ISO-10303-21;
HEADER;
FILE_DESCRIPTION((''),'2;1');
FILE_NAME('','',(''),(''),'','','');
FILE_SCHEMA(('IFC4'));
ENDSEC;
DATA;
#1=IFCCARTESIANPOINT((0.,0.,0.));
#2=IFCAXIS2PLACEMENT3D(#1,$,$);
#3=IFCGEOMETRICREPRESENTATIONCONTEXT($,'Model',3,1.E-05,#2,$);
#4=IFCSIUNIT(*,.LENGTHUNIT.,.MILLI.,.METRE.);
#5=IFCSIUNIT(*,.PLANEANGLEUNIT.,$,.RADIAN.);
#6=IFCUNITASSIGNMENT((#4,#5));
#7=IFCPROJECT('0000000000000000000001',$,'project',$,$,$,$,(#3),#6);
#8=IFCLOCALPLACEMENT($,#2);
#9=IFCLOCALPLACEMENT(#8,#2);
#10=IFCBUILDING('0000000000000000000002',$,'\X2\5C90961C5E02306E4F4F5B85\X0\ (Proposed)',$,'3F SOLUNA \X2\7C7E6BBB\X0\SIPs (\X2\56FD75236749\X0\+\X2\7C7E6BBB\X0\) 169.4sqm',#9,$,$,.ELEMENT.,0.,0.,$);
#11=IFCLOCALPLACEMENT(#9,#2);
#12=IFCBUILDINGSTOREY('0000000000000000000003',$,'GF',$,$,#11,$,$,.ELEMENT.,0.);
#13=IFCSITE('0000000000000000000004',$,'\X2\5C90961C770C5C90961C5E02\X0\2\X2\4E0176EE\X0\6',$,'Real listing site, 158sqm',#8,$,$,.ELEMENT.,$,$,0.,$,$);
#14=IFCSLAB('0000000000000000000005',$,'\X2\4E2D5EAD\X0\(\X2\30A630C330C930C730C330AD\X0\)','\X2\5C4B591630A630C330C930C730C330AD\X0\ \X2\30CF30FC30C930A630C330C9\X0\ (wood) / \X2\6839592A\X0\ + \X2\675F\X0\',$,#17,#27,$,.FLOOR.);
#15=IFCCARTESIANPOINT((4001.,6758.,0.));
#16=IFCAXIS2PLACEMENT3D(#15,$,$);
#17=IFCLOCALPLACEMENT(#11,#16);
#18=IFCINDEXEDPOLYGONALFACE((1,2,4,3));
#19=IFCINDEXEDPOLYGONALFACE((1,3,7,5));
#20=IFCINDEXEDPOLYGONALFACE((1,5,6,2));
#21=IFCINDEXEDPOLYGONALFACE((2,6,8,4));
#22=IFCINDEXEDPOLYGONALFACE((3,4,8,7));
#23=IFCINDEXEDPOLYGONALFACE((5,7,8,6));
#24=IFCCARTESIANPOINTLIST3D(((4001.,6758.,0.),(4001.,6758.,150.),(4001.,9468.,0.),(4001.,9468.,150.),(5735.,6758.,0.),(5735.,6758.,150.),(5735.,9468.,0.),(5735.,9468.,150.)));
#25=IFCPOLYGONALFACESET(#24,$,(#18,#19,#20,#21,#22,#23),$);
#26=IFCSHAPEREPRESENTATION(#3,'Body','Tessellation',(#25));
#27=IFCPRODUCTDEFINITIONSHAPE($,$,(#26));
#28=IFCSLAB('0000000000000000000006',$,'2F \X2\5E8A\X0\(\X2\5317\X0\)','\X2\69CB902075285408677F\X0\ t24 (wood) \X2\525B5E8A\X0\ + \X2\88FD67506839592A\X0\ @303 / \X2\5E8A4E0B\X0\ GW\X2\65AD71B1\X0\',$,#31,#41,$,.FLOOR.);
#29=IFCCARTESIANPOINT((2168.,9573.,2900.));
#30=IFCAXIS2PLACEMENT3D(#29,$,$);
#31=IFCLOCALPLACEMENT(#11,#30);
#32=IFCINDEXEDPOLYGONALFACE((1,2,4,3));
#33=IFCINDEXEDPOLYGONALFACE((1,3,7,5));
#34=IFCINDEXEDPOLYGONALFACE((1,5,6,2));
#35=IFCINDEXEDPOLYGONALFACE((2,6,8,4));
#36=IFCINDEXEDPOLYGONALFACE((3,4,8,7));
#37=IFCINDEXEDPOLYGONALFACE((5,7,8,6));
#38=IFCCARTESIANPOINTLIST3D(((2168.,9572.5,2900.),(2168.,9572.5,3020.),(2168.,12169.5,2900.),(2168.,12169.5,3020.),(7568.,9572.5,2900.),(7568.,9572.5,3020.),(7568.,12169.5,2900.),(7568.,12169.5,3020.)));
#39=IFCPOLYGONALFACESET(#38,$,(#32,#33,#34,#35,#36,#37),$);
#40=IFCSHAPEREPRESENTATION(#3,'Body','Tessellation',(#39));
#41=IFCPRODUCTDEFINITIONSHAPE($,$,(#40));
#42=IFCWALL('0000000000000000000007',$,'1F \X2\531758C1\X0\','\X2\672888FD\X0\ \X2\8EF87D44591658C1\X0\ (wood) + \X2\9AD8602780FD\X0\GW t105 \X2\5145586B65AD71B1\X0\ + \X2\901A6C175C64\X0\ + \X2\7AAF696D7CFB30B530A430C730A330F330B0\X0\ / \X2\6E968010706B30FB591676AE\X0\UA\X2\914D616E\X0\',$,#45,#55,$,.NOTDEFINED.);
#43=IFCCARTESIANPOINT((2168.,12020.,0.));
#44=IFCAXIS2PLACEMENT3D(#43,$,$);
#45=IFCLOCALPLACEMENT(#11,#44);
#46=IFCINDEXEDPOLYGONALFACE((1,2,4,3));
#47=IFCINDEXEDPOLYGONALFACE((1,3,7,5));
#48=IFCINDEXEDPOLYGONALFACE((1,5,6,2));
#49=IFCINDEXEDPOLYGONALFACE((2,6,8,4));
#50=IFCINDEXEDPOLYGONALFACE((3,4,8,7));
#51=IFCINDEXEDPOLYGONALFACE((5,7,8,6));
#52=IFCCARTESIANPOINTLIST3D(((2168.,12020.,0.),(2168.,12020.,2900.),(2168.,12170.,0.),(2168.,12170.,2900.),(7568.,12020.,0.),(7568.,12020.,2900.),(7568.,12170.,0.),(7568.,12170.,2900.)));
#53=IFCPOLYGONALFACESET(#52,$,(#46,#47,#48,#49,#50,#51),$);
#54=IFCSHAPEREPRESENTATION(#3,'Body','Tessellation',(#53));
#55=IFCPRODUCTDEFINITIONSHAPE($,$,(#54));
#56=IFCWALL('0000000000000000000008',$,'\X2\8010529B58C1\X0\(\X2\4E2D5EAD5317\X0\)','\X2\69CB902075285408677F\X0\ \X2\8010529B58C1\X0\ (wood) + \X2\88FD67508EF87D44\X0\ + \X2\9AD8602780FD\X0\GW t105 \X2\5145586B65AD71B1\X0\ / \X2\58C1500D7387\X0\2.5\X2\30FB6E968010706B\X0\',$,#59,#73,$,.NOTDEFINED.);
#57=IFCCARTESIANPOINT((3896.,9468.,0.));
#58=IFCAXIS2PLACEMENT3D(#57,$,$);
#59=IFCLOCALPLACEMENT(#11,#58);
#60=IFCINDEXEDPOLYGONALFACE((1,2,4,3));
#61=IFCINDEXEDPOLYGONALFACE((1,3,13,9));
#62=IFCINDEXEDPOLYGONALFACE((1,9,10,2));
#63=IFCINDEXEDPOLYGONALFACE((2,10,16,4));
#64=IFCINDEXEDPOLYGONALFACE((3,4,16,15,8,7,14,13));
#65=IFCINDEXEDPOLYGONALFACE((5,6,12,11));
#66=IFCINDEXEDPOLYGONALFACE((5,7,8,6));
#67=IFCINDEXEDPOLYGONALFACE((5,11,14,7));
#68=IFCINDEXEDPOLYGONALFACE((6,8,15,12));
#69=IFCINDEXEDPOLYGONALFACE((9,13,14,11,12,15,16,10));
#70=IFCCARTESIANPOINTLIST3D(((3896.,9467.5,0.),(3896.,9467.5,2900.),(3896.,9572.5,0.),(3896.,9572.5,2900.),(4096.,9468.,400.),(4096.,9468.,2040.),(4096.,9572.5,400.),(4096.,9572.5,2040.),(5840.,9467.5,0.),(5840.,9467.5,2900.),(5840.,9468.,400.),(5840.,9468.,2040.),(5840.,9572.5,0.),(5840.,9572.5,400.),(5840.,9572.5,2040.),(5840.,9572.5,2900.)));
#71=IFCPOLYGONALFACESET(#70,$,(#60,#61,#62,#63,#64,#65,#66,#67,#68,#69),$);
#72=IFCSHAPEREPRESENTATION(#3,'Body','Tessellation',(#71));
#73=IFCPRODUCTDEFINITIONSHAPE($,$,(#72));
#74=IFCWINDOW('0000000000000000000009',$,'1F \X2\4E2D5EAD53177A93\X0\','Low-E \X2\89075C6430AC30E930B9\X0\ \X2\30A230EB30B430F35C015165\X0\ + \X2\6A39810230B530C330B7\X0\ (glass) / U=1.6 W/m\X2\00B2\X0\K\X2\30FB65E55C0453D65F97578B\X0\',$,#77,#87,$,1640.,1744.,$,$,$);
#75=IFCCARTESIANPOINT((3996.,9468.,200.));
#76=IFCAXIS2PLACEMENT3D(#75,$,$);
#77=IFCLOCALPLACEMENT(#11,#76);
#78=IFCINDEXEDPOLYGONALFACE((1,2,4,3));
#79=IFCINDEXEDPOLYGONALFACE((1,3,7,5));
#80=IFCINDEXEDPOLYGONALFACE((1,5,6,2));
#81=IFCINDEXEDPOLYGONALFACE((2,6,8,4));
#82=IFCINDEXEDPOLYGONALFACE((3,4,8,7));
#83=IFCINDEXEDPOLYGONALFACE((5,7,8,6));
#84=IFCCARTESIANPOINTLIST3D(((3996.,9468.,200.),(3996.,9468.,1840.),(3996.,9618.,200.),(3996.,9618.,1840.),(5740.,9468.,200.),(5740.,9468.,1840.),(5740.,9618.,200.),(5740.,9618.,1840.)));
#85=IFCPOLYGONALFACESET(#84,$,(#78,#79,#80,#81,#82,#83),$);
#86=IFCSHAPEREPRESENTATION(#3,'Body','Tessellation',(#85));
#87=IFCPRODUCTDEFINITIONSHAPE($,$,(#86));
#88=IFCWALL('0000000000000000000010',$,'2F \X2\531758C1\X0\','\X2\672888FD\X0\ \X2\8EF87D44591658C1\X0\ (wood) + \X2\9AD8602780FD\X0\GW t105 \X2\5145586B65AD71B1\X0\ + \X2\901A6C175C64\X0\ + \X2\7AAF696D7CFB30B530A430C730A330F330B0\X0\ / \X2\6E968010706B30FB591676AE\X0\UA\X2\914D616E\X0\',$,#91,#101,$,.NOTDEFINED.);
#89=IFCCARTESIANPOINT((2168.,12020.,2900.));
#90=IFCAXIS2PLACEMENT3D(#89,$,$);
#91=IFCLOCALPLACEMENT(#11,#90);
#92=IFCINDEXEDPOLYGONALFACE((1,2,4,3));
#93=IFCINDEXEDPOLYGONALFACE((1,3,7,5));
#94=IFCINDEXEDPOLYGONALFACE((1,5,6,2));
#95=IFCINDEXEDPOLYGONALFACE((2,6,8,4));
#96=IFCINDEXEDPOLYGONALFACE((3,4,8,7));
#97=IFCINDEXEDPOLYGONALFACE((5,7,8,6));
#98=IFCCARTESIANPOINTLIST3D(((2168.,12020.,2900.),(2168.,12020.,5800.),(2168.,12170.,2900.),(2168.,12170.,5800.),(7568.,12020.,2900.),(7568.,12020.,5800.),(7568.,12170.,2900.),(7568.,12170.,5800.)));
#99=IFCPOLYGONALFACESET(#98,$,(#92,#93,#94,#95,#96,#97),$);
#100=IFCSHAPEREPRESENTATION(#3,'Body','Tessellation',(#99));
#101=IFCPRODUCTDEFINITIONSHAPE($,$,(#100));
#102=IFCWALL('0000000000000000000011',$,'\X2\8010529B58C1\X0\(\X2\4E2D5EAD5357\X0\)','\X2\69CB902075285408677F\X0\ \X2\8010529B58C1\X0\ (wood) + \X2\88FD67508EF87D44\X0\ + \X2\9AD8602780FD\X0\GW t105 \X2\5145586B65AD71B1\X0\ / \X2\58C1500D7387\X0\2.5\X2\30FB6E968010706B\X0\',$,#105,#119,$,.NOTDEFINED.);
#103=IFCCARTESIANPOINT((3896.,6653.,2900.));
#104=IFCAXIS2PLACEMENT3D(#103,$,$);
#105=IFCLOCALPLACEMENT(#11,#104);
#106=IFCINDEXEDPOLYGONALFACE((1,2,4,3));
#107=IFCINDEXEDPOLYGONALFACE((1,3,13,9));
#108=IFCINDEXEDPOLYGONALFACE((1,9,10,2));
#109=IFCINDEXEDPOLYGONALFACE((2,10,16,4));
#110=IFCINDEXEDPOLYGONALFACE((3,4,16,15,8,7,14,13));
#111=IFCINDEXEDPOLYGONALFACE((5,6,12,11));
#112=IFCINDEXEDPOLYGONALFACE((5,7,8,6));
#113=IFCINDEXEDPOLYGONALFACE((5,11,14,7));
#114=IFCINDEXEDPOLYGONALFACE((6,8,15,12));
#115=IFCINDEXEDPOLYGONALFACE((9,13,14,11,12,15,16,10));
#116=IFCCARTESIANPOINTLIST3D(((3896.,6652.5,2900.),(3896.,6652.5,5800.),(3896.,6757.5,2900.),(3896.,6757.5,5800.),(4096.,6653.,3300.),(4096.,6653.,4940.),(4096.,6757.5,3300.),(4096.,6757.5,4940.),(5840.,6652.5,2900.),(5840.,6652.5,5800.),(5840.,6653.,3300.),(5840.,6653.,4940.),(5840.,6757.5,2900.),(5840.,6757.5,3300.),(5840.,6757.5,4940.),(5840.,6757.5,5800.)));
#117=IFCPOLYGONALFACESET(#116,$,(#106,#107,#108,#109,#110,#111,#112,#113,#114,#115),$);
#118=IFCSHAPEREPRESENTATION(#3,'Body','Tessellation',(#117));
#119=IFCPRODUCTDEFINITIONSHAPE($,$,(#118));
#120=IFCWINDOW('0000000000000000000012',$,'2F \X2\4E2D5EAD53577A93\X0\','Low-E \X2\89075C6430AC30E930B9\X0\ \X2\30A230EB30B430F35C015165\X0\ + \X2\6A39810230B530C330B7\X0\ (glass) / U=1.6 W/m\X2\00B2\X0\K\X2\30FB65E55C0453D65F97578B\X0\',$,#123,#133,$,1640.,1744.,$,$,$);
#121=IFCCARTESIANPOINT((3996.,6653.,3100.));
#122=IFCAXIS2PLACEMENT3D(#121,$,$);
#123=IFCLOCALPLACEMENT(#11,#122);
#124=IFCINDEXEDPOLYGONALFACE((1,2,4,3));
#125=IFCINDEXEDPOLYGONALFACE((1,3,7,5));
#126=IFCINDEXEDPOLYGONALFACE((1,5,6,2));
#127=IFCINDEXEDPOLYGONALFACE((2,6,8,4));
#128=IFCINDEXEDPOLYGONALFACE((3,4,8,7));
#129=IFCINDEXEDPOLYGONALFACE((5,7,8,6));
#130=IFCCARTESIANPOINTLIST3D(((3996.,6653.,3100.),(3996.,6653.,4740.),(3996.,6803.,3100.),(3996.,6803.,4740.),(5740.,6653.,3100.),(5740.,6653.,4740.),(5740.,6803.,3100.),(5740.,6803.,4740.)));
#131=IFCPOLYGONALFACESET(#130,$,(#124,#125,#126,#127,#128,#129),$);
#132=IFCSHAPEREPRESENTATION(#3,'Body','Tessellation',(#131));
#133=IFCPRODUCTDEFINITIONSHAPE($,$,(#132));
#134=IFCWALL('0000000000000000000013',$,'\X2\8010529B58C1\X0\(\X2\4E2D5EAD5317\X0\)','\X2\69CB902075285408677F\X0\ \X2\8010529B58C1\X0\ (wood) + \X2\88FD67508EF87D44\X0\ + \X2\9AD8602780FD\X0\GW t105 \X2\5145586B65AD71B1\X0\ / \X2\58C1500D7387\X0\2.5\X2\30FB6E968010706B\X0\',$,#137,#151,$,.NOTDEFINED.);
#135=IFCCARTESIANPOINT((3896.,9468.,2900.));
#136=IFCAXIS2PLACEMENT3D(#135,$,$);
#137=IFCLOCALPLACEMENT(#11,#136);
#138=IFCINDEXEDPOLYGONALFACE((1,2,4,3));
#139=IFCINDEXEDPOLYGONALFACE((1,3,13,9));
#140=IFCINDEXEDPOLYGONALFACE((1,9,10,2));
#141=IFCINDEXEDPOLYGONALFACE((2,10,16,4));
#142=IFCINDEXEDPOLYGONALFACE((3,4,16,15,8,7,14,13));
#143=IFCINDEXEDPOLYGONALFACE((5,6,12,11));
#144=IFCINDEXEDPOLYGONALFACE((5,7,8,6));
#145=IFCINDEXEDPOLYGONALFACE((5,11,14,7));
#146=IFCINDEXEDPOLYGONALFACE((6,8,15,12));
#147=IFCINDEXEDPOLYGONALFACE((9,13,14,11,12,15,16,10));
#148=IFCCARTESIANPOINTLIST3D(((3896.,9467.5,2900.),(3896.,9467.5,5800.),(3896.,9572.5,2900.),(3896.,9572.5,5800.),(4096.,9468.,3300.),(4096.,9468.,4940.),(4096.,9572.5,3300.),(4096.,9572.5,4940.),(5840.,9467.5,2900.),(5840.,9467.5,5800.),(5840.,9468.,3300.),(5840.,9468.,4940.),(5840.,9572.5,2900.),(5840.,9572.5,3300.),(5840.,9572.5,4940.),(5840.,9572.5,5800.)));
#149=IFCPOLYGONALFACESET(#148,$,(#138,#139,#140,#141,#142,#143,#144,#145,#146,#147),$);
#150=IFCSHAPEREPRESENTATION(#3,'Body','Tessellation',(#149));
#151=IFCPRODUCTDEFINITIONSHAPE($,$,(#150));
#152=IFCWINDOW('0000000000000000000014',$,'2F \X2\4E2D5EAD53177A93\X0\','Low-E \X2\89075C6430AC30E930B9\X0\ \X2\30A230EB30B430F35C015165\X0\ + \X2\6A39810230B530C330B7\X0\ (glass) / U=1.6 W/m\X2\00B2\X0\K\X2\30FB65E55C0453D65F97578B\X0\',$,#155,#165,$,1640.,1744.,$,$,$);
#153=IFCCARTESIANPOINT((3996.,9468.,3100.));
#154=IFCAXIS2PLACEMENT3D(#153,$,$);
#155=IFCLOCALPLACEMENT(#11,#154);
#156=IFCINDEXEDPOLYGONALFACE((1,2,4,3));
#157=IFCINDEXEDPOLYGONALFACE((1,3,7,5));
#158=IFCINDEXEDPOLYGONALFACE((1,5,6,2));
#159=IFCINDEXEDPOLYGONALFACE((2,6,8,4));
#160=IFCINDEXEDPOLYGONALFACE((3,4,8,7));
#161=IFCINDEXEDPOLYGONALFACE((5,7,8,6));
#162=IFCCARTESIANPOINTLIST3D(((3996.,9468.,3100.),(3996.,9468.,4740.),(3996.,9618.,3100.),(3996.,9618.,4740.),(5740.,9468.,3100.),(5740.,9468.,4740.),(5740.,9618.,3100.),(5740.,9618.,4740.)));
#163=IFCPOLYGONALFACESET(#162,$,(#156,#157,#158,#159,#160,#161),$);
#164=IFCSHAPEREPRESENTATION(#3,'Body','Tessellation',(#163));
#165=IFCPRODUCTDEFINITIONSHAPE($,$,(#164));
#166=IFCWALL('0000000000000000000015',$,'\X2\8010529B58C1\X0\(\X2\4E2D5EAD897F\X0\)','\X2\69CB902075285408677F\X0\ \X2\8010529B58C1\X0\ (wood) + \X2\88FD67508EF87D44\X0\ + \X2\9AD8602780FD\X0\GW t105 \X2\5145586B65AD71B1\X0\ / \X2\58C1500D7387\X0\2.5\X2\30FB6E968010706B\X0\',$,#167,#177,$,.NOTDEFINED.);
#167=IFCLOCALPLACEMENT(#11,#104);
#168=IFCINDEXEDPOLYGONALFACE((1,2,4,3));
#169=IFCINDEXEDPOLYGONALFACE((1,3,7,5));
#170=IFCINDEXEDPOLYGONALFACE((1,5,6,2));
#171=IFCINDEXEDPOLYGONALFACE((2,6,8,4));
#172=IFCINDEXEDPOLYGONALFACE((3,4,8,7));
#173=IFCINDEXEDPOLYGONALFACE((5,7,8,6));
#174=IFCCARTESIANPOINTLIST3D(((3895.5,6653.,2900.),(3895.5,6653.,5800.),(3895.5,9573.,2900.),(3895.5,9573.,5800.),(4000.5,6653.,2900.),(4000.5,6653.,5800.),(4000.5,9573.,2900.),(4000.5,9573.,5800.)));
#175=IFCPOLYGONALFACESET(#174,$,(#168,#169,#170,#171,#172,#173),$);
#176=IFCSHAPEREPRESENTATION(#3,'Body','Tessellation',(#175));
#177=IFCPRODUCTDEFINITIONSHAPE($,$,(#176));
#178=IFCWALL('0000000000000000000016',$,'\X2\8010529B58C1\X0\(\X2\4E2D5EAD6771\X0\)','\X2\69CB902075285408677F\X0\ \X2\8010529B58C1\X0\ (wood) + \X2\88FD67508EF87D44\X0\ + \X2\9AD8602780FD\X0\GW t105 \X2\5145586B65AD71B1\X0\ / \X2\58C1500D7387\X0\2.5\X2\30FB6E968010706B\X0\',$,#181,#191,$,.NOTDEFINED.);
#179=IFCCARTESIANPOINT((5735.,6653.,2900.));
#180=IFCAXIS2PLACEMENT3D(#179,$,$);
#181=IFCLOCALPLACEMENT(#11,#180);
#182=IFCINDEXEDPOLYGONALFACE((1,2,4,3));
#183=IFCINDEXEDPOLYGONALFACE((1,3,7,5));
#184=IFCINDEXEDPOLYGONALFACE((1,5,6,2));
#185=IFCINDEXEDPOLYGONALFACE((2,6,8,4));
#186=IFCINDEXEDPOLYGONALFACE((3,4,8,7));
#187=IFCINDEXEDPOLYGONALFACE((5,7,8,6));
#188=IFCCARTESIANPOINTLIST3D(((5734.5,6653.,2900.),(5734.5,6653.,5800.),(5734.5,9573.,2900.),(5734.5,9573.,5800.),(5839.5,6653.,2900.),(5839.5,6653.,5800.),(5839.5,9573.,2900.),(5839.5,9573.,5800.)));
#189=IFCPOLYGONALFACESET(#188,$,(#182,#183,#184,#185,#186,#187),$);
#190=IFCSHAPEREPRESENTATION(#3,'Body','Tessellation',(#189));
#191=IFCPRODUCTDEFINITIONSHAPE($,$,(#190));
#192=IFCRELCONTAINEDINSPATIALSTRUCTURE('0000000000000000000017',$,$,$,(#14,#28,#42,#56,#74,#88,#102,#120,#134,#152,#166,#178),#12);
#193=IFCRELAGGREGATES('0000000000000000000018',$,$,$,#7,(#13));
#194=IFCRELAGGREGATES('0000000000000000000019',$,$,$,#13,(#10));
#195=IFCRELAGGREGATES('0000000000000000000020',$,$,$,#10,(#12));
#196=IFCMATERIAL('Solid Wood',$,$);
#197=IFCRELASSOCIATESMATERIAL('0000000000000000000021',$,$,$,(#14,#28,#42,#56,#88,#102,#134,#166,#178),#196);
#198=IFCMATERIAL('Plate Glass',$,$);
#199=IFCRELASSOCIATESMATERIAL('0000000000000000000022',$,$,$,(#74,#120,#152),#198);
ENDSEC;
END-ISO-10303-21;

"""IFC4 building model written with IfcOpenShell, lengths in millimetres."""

from ifc_helpers import new_model, si_unit, frame, frame_2d, origin, place, context, project, spatial, rectangle, extrude, material, element, fill, save


model = new_model("IFC4")

# Units and contexts
model_context = context("Model", 3, precision=1e-05, world=origin())
ifc_project = project(units=[si_unit("LENGTHUNIT", "METRE", prefix="MILLI"), si_unit("PLANEANGLEUNIT", "RADIAN")], contexts=[model_context])

# Site, building, storey
site_placement = place(None, origin())
site = spatial("IfcSite", under=ifc_project, at=site_placement, Name="岐阜県岐阜市2丁目6", ObjectType="Real listing site, 158sqm", CompositionType="ELEMENT", RefElevation=0.0)
building_placement = place(site_placement, origin())
building = spatial("IfcBuilding", under=site, at=building_placement, Name="岐阜市の住宅 (Proposed)", ObjectType="3F SOLUNA 籾殻SIPs (国産杉+籾殻) 169.4sqm", CompositionType="ELEMENT", ElevationOfRefHeight=0.0, ElevationOfTerrain=0.0)
storey_placement = place(building_placement, origin())
storey = spatial("IfcBuildingStorey", under=building, at=storey_placement, Name="GF", CompositionType="ELEMENT", Elevation=0.0)

# Slabs
ifc_material_1 = material(Name="Solid Wood")
slab_1_placement = place(storey_placement, frame((4001.0, 6758.0, 0.0)))
element("IfcSlab", 1, at=slab_1_placement, inside=storey, material=ifc_material_1, Name="中庭(ウッドデッキ)", Description="屋外ウッドデッキ ハードウッド (wood) / 根太 + 束", PredefinedType="FLOOR", context=model_context, shape_type="SweptSolid", body=[
    extrude(rectangle(XDim=1734.0, YDim=2710.0, at=frame_2d((867.0, 1355.0))), frame((4001.0, 6758.0, 0.0)), (0.0, 0.0, 1.0), 150.0),
])
slab_2_placement = place(storey_placement, frame((2168.0, 9573.0, 2900.0)))
element("IfcSlab", 2, at=slab_2_placement, inside=storey, material=ifc_material_1, Name="2F 床(北)", Description="構造用合板 t24 (wood) 剛床 + 製材根太 @303 / 床下 GW断熱", PredefinedType="FLOOR", context=model_context, shape_type="SweptSolid", body=[
    extrude(rectangle(XDim=5400.0, YDim=2597.0, at=frame_2d((2700.0, 1298.0))), frame((2168.0, 9573.0, 2900.0)), (0.0, 0.0, 1.0), 120.0),
])

# Wall
wall_1_placement = place(storey_placement, frame((2168.0, 12020.0, 0.0)))
element("IfcWall", 3, at=wall_1_placement, inside=storey, material=ifc_material_1, Name="1F 北壁", Description="木製 軸組外壁 (wood) + 高性能GW t105 充填断熱 + 通気層 + 窯業系サイディング / 準耐火・外皮UA配慮", PredefinedType="NOTDEFINED", context=model_context, shape_type="SweptSolid", body=[
    extrude(rectangle(XDim=5400.0, YDim=150.0, at=frame_2d((2700.0, 75.0))), frame((2168.0, 12020.0, 0.0)), (0.0, 0.0, 1.0), 2900.0),
])

# Wall, opening, window
wall_2_placement = place(storey_placement, frame((3896.0, 9468.0, 0.0)))
wall_2 = element("IfcWall", 4, at=wall_2_placement, inside=storey, material=ifc_material_1, Name="耐力壁(中庭北)", Description="構造用合板 耐力壁 (wood) + 製材軸組 + 高性能GW t105 充填断熱 / 壁倍率2.5・準耐火", PredefinedType="NOTDEFINED", context=model_context, shape_type="SweptSolid", body=[
    extrude(rectangle(XDim=1944.0, YDim=105.0, at=frame_2d((972.0, 52.0))), frame((3896.0, 9468.0, 0.0)), (0.0, 0.0, 1.0), 2900.0),
])
opening_1_placement = place(storey_placement, frame((3996.0, 9468.0, 200.0)))
opening_1 = element("IfcOpeningElement", 5, at=opening_1_placement, cuts=wall_2, PredefinedType="NOTDEFINED", context=model_context, shape_type="SweptSolid", body=[
    extrude(rectangle(XDim=1744.0, YDim=150.0, at=frame_2d((872.0, 75.0))), frame((3996.0, 9468.0, 200.0)), (0.0, 0.0, 1.0), 1640.0),
])
ifc_material_2 = material(Name="Plate Glass")
window_1_placement = place(storey_placement, frame((3996.0, 9468.0, 200.0)))
window_1 = element("IfcWindow", 6, at=window_1_placement, inside=storey, material=ifc_material_2, Name="1F 中庭北窓", Description="Low-E 複層ガラス アルゴン封入 + 樹脂サッシ (glass) / U=1.6 W/m²K・日射取得型", OverallHeight=1640.0, OverallWidth=1744.0, context=model_context, shape_type="SweptSolid", body=[
    extrude(rectangle(XDim=1744.0, YDim=150.0, at=frame_2d((872.0, 75.0))), frame((3996.0, 9468.0, 200.0)), (0.0, 0.0, 1.0), 1640.0),
])
fill(opening_1, window_1)

# Wall
wall_3_placement = place(storey_placement, frame((2168.0, 12020.0, 2900.0)))
element("IfcWall", 7, at=wall_3_placement, inside=storey, material=ifc_material_1, Name="2F 北壁", Description="木製 軸組外壁 (wood) + 高性能GW t105 充填断熱 + 通気層 + 窯業系サイディング / 準耐火・外皮UA配慮", PredefinedType="NOTDEFINED", context=model_context, shape_type="SweptSolid", body=[
    extrude(rectangle(XDim=5400.0, YDim=150.0, at=frame_2d((2700.0, 75.0))), frame((2168.0, 12020.0, 2900.0)), (0.0, 0.0, 1.0), 2900.0),
])

# Walls, openings, windows
wall_4_placement = place(storey_placement, frame((3896.0, 6653.0, 2900.0)))
wall_4 = element("IfcWall", 8, at=wall_4_placement, inside=storey, material=ifc_material_1, Name="耐力壁(中庭南)", Description="構造用合板 耐力壁 (wood) + 製材軸組 + 高性能GW t105 充填断熱 / 壁倍率2.5・準耐火", PredefinedType="NOTDEFINED", context=model_context, shape_type="SweptSolid", body=[
    extrude(rectangle(XDim=1944.0, YDim=105.0, at=frame_2d((972.0, 52.0))), frame((3896.0, 6653.0, 2900.0)), (0.0, 0.0, 1.0), 2900.0),
])
opening_2_placement = place(storey_placement, frame((3996.0, 6653.0, 3100.0)))
opening_2 = element("IfcOpeningElement", 9, at=opening_2_placement, cuts=wall_4, PredefinedType="NOTDEFINED", context=model_context, shape_type="SweptSolid", body=[
    extrude(rectangle(XDim=1744.0, YDim=150.0, at=frame_2d((872.0, 75.0))), frame((3996.0, 6653.0, 3100.0)), (0.0, 0.0, 1.0), 1640.0),
])
window_2_placement = place(storey_placement, frame((3996.0, 6653.0, 3100.0)))
window_2 = element("IfcWindow", 10, at=window_2_placement, inside=storey, material=ifc_material_2, Name="2F 中庭南窓", Description="Low-E 複層ガラス アルゴン封入 + 樹脂サッシ (glass) / U=1.6 W/m²K・日射取得型", OverallHeight=1640.0, OverallWidth=1744.0, context=model_context, shape_type="SweptSolid", body=[
    extrude(rectangle(XDim=1744.0, YDim=150.0, at=frame_2d((872.0, 75.0))), frame((3996.0, 6653.0, 3100.0)), (0.0, 0.0, 1.0), 1640.0),
])
fill(opening_2, window_2)
wall_5_placement = place(storey_placement, frame((3896.0, 9468.0, 2900.0)))
wall_5 = element("IfcWall", 11, at=wall_5_placement, inside=storey, material=ifc_material_1, Name="耐力壁(中庭北)", Description="構造用合板 耐力壁 (wood) + 製材軸組 + 高性能GW t105 充填断熱 / 壁倍率2.5・準耐火", PredefinedType="NOTDEFINED", context=model_context, shape_type="SweptSolid", body=[
    extrude(rectangle(XDim=1944.0, YDim=105.0, at=frame_2d((972.0, 52.0))), frame((3896.0, 9468.0, 2900.0)), (0.0, 0.0, 1.0), 2900.0),
])
opening_3_placement = place(storey_placement, frame((3996.0, 9468.0, 3100.0)))
opening_3 = element("IfcOpeningElement", 12, at=opening_3_placement, cuts=wall_5, PredefinedType="NOTDEFINED", context=model_context, shape_type="SweptSolid", body=[
    extrude(rectangle(XDim=1744.0, YDim=150.0, at=frame_2d((872.0, 75.0))), frame((3996.0, 9468.0, 3100.0)), (0.0, 0.0, 1.0), 1640.0),
])
window_3_placement = place(storey_placement, frame((3996.0, 9468.0, 3100.0)))
window_3 = element("IfcWindow", 13, at=window_3_placement, inside=storey, material=ifc_material_2, Name="2F 中庭北窓", Description="Low-E 複層ガラス アルゴン封入 + 樹脂サッシ (glass) / U=1.6 W/m²K・日射取得型", OverallHeight=1640.0, OverallWidth=1744.0, context=model_context, shape_type="SweptSolid", body=[
    extrude(rectangle(XDim=1744.0, YDim=150.0, at=frame_2d((872.0, 75.0))), frame((3996.0, 9468.0, 3100.0)), (0.0, 0.0, 1.0), 1640.0),
])
fill(opening_3, window_3)

# Walls
wall_6_placement = place(storey_placement, frame((3896.0, 6653.0, 2900.0)))
element("IfcWall", 14, at=wall_6_placement, inside=storey, material=ifc_material_1, Name="耐力壁(中庭西)", Description="構造用合板 耐力壁 (wood) + 製材軸組 + 高性能GW t105 充填断熱 / 壁倍率2.5・準耐火", PredefinedType="NOTDEFINED", context=model_context, shape_type="SweptSolid", body=[
    extrude(rectangle(XDim=105.0, YDim=2920.0, at=frame_2d((52.0, 1460.0))), frame((3896.0, 6653.0, 2900.0)), (0.0, 0.0, 1.0), 2900.0),
])
wall_7_placement = place(storey_placement, frame((5735.0, 6653.0, 2900.0)))
element("IfcWall", 15, at=wall_7_placement, inside=storey, material=ifc_material_1, Name="耐力壁(中庭東)", Description="構造用合板 耐力壁 (wood) + 製材軸組 + 高性能GW t105 充填断熱 / 壁倍率2.5・準耐火", PredefinedType="NOTDEFINED", context=model_context, shape_type="SweptSolid", body=[
    extrude(rectangle(XDim=105.0, YDim=2920.0, at=frame_2d((52.0, 1460.0))), frame((5735.0, 6653.0, 2900.0)), (0.0, 0.0, 1.0), 2900.0),
])

save(model, "model.ifc")
